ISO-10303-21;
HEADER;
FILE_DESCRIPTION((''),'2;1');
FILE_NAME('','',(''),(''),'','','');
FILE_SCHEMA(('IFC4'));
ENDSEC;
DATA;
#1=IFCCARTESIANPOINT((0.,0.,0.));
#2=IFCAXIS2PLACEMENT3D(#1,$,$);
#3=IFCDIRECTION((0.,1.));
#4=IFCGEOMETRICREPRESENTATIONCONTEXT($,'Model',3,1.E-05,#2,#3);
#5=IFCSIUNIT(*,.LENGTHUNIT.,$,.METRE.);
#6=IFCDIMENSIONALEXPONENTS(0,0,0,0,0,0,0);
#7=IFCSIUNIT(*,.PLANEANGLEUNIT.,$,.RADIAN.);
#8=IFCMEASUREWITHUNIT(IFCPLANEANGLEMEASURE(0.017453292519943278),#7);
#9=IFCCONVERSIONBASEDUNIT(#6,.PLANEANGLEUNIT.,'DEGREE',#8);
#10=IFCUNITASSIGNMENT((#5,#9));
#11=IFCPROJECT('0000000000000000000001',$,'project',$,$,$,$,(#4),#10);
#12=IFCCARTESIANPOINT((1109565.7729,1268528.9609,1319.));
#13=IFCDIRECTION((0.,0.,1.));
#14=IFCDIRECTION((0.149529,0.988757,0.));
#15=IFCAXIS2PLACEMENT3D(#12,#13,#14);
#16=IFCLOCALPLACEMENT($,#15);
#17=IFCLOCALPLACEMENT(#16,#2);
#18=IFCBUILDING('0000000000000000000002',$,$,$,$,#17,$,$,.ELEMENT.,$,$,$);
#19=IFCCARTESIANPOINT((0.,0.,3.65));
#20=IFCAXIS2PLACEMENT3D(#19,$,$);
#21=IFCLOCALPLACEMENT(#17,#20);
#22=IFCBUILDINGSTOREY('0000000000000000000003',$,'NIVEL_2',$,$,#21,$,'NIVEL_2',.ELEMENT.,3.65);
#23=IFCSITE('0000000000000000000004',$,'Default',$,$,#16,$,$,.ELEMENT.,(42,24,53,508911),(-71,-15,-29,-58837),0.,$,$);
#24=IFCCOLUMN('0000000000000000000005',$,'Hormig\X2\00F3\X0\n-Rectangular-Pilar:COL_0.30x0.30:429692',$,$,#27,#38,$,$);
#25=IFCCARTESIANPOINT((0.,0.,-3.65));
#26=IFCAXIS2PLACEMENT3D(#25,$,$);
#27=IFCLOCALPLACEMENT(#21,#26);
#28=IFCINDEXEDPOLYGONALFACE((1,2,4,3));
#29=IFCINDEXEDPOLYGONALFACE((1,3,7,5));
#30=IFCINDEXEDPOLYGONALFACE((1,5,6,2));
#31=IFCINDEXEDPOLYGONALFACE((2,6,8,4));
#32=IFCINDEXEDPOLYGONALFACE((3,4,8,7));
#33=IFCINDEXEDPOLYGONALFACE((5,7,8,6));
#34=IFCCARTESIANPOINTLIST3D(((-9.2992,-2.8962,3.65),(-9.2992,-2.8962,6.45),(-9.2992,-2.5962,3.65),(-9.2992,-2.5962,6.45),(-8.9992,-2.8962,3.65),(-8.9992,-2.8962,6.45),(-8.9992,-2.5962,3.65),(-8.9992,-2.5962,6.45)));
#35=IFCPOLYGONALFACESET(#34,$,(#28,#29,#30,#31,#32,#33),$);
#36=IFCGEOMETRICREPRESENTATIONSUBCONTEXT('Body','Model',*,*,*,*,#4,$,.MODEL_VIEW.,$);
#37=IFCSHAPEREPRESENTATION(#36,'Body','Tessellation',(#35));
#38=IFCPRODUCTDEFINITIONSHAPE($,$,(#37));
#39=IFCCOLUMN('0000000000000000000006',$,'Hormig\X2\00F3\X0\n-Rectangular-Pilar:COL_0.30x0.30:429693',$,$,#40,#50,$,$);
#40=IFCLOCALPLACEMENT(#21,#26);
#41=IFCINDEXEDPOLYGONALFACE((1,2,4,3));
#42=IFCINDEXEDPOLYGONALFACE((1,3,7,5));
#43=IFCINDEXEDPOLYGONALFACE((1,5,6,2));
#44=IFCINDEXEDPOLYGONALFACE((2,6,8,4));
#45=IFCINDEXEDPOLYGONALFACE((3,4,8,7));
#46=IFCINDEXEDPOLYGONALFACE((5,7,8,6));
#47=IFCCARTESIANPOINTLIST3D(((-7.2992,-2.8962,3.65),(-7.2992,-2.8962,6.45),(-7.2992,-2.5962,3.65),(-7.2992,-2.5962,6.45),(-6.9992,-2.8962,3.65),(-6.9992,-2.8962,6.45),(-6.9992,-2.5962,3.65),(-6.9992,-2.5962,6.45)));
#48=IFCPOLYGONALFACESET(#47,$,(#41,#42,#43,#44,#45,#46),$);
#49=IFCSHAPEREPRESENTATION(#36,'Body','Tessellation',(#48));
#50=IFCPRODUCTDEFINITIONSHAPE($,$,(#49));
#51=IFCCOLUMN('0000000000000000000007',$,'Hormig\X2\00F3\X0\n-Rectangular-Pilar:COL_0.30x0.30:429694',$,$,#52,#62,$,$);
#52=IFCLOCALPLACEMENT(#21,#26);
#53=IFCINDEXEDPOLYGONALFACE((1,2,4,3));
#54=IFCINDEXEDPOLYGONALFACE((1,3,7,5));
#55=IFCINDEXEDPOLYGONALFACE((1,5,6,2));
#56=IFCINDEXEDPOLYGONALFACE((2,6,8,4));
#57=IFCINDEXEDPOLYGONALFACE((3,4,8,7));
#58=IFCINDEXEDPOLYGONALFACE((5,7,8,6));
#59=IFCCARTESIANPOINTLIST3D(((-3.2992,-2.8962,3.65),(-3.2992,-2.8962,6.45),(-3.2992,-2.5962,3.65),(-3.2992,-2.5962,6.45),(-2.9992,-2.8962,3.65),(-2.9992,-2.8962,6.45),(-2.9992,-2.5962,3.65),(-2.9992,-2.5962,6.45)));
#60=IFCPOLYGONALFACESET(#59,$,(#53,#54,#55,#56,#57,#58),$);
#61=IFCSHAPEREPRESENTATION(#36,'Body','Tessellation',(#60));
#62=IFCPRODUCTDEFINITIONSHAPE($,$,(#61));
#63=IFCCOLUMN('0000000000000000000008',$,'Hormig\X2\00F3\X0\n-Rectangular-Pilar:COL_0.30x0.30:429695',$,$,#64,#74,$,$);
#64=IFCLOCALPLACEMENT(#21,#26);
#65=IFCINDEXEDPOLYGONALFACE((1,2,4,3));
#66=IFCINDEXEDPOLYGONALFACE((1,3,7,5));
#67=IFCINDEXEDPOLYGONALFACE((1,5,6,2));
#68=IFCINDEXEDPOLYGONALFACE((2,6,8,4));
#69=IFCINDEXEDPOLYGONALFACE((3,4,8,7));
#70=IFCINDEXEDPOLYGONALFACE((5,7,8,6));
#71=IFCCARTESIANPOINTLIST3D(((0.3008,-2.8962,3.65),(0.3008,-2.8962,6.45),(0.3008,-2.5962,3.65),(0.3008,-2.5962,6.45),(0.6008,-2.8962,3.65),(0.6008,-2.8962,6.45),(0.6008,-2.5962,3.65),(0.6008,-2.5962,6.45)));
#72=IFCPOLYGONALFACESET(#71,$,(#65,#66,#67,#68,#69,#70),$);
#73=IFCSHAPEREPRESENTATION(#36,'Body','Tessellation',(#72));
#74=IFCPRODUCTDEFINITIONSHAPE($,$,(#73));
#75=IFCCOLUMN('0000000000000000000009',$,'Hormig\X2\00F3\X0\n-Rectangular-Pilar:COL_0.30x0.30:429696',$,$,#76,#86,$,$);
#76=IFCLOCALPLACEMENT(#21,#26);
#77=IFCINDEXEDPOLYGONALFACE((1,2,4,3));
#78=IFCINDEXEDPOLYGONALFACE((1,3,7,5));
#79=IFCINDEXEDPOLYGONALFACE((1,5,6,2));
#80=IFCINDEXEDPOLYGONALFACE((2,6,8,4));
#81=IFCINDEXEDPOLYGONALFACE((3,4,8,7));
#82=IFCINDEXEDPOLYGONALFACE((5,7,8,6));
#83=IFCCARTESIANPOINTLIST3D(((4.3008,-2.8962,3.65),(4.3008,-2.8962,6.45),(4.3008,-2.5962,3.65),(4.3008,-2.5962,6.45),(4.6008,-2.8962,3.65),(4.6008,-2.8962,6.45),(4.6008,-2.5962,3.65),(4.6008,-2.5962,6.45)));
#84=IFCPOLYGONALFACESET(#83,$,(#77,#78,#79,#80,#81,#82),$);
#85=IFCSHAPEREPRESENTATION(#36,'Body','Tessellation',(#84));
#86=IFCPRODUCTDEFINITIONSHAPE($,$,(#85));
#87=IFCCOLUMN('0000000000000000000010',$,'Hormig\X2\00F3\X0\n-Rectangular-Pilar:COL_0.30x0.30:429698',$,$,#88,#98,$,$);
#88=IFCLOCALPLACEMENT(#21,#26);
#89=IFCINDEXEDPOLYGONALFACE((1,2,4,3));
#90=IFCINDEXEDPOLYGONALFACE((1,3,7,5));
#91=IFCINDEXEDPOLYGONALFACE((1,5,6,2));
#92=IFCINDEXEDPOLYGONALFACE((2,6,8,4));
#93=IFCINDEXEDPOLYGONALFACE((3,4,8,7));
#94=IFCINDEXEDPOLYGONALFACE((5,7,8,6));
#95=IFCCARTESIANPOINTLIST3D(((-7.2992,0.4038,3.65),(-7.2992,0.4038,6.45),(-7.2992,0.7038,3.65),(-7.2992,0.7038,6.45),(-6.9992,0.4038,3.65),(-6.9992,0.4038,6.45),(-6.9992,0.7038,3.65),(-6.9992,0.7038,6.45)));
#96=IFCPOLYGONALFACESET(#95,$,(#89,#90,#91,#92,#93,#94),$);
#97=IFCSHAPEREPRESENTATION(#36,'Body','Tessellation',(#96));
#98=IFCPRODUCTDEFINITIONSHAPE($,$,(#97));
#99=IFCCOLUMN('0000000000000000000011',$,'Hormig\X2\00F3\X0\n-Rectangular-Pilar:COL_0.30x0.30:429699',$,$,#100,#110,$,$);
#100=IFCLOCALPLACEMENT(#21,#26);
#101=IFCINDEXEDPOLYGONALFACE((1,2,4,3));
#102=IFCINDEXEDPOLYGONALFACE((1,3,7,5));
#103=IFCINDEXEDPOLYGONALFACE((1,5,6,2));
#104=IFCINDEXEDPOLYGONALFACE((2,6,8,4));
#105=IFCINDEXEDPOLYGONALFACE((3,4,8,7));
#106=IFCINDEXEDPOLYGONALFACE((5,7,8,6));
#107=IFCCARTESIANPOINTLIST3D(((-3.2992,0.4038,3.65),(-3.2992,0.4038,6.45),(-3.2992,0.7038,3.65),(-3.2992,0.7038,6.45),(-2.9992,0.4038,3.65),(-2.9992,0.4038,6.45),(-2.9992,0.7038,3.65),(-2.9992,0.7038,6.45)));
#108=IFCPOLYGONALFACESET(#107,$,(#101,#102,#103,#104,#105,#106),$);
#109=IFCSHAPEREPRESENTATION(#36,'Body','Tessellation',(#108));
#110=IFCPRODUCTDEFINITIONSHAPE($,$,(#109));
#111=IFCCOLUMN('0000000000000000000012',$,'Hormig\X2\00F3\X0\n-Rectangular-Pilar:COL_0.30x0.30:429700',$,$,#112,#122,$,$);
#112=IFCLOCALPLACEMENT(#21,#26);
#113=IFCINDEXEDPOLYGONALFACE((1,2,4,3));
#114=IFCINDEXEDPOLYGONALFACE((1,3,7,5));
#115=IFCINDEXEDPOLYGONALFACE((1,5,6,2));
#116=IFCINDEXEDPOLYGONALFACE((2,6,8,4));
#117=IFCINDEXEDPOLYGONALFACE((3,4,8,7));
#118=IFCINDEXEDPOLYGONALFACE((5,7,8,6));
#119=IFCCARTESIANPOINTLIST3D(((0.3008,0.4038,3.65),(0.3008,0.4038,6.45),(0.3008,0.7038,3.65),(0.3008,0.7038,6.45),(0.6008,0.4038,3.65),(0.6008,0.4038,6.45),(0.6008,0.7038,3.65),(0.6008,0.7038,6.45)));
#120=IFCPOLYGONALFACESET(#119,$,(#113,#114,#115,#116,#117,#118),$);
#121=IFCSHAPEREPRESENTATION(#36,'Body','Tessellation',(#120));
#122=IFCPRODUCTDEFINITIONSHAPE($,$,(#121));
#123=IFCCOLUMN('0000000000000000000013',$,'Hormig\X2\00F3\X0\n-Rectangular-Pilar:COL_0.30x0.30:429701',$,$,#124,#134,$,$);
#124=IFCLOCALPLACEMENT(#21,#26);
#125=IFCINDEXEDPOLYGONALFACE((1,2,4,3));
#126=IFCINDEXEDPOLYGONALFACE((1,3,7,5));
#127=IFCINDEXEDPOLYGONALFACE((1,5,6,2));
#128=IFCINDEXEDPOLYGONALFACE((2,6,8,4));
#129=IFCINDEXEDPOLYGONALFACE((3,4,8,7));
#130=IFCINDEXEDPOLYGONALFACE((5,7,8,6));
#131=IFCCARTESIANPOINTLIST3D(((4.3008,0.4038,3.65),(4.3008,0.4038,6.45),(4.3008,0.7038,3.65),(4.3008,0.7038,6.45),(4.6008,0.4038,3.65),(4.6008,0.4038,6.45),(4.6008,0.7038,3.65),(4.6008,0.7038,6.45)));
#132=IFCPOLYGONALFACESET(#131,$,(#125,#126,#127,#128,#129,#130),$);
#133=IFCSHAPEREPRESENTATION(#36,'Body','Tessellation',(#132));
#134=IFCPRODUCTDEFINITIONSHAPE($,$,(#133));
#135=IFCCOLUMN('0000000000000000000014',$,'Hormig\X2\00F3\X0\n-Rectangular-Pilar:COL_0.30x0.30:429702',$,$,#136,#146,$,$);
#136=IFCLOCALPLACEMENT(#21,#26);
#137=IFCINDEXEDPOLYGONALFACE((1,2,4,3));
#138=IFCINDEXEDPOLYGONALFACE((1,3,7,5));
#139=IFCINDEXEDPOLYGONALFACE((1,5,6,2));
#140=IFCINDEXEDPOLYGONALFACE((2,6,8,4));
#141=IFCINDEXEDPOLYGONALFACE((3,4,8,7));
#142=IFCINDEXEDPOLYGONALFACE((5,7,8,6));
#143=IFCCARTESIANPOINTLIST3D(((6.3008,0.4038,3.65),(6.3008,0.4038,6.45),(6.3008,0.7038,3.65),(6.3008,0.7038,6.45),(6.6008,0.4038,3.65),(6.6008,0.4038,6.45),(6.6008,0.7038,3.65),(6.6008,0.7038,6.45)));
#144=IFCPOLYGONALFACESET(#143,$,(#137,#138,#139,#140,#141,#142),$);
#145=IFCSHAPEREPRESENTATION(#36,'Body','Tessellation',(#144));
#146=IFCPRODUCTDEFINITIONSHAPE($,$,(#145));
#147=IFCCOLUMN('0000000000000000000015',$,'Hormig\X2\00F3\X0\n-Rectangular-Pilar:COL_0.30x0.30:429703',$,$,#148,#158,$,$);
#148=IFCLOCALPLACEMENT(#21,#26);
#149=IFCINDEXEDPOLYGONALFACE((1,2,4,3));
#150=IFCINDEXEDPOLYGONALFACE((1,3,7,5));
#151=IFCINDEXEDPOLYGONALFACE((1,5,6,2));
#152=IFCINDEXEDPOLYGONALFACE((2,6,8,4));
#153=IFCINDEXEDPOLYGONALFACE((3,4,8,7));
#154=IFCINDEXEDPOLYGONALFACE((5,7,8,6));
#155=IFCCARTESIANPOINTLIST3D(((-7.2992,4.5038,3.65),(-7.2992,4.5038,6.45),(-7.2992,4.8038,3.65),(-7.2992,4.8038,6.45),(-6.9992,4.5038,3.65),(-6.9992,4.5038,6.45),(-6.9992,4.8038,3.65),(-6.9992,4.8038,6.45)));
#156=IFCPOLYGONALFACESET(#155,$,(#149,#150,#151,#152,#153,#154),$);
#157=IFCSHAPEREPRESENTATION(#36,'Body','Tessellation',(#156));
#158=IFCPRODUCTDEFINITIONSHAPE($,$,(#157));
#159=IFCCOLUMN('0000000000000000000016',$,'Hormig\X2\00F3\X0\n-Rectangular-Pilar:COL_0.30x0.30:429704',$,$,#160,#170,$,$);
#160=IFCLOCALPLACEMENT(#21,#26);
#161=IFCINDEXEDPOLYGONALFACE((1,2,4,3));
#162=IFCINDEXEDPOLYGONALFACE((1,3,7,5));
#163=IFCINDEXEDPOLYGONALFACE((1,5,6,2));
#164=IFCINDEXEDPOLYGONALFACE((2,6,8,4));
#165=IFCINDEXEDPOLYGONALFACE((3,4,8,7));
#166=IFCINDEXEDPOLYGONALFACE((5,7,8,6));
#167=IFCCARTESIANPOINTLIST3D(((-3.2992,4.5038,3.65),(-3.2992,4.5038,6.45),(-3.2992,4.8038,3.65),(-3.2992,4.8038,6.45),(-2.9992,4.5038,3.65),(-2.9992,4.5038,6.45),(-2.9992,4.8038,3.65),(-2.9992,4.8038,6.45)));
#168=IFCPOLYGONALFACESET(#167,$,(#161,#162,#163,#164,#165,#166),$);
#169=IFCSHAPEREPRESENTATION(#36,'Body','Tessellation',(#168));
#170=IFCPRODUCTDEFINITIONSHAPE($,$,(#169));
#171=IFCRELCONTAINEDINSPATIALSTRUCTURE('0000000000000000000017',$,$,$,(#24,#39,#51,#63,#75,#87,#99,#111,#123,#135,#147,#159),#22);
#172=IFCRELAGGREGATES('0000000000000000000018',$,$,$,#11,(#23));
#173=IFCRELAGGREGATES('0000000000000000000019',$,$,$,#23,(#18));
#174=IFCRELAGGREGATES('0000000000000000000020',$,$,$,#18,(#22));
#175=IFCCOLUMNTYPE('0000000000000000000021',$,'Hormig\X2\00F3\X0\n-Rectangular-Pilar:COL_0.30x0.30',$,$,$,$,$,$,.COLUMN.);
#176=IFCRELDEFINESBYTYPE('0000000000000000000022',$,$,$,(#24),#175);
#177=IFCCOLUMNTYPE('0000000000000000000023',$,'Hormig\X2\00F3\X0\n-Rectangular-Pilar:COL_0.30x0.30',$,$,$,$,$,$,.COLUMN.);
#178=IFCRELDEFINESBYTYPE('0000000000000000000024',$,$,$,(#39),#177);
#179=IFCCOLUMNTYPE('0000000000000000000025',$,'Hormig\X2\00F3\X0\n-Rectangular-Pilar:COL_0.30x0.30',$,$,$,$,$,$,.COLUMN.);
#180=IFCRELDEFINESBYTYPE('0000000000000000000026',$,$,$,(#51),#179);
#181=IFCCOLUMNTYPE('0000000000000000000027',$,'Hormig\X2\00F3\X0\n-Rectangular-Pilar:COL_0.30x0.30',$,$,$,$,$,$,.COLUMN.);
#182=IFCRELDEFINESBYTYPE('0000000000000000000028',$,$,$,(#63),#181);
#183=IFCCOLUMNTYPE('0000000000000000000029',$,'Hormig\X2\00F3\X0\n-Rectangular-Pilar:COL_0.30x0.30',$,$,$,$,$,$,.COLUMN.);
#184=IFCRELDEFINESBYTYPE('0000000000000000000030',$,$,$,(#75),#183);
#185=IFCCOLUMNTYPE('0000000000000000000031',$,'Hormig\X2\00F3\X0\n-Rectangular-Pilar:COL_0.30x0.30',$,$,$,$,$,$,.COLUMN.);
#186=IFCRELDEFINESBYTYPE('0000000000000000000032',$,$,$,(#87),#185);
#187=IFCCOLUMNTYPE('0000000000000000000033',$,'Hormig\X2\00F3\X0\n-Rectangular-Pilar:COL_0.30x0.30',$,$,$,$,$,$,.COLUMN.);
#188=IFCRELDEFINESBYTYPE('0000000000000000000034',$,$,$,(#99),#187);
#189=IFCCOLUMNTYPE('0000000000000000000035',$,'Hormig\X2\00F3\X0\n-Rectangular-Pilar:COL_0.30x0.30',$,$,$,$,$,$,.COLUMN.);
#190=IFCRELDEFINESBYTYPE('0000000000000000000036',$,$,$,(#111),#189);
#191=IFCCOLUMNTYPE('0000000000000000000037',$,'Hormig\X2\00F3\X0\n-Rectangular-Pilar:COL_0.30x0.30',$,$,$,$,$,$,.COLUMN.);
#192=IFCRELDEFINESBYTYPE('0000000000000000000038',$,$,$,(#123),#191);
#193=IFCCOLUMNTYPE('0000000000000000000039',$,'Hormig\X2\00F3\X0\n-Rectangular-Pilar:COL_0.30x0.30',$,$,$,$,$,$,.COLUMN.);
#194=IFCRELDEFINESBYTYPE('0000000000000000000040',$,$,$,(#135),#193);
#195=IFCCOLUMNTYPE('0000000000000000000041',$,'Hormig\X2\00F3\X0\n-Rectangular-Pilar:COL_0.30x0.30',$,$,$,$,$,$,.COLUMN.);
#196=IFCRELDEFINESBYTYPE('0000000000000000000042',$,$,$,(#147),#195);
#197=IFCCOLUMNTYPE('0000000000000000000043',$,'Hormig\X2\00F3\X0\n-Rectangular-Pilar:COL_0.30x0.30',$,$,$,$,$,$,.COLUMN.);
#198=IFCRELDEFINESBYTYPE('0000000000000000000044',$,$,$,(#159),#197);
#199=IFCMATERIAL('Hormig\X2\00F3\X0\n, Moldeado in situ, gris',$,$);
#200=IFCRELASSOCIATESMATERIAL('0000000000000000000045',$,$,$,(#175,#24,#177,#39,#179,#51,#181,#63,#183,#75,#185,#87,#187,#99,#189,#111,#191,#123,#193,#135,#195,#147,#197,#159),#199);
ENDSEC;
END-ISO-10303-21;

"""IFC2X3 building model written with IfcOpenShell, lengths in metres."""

from ifc_helpers import new_model, entity, si_unit, converted_unit, direction, frame, frame_2d, origin, origin_2d_with_axis, place, context, subcontext, project, spatial, rectangle, extrude, source, transform, mapped, material, type_object, type_shapes, element, save


model = new_model("IFC2X3")

# Units and contexts
model_context = context("Model", 3, precision=1e-05, world=origin(), true_north=direction((0.0, 1.0)))
body_context = subcontext(model_context, "Body", "Model", "MODEL_VIEW")
ifc_project = project(units=[si_unit("LENGTHUNIT", "METRE"), converted_unit("PLANEANGLEUNIT", "DEGREE", entity("IfcPlaneAngleMeasure", 0.017453292519943278), si_unit("PLANEANGLEUNIT", "RADIAN"), dimensions=[0, 0, 0, 0, 0, 0, 0])], contexts=[model_context])

# Site, building, storey
site_placement = place(None, frame((1109565.7729, 1268528.9609, 1319.0), z_axis=(0.0, 0.0, 1.0), x_axis=(0.149529, 0.988757, 0.0)))
site = spatial("IfcSite", under=ifc_project, at=site_placement, Name="Default", CompositionType="ELEMENT", RefLatitude=(42, 24, 53, 508911), RefLongitude=(-71, -15, -29, -58837), RefElevation=0.0)
building_placement = place(site_placement, origin())
building = spatial("IfcBuilding", under=site, at=building_placement, CompositionType="ELEMENT")
storey_placement = place(building_placement, frame((0.0, 0.0, 3.65)))
storey = spatial("IfcBuildingStorey", under=building, at=storey_placement, Name="NIVEL_2", LongName="NIVEL_2", CompositionType="ELEMENT", Elevation=3.65)

# Columns
ifc_material_1 = material(Name="Hormigón, Moldeado in situ, gris")
column_type_1 = type_object("IfcColumnType", Name="Hormigón-Rectangular-Pilar:COL_0.30x0.30", PredefinedType="COLUMN", material=ifc_material_1)
shared_shape_1 = source(origin(), body_context, "Body", "SweptSolid", [
    extrude(rectangle(XDim=0.3, YDim=0.3, at=origin_2d_with_axis()), frame((-9.1492, -2.7462, 3.65)), (0.0, 0.0, 1.0), 2.8),
])
type_shapes(column_type_1, [shared_shape_1])
column_1_placement = place(storey_placement, frame((0.0, 0.0, -3.65)))
element("IfcColumn", 1, at=column_1_placement, inside=storey, type_object=column_type_1, material=ifc_material_1, Name="Hormigón-Rectangular-Pilar:COL_0.30x0.30:429692", context=body_context, shape_type="MappedRepresentation", body=[
    mapped(shared_shape_1, transform((0.0, 0.0, 0.0), scale=1.0)),
])
column_type_2 = type_object("IfcColumnType", Name="Hormigón-Rectangular-Pilar:COL_0.30x0.30", PredefinedType="COLUMN", material=ifc_material_1)
shared_shape_2 = source(origin(), body_context, "Body", "SweptSolid", [
    extrude(rectangle(XDim=0.3, YDim=0.3, at=origin_2d_with_axis()), frame((-7.1492, -2.7462, 3.65)), (0.0, 0.0, 1.0), 2.8),
])
type_shapes(column_type_2, [shared_shape_2])
column_2_placement = place(storey_placement, frame((0.0, 0.0, -3.65)))
element("IfcColumn", 2, at=column_2_placement, inside=storey, type_object=column_type_2, material=ifc_material_1, Name="Hormigón-Rectangular-Pilar:COL_0.30x0.30:429693", context=body_context, shape_type="MappedRepresentation", body=[
    mapped(shared_shape_2, transform((0.0, 0.0, 0.0), scale=1.0)),
])
column_type_3 = type_object("IfcColumnType", Name="Hormigón-Rectangular-Pilar:COL_0.30x0.30", PredefinedType="COLUMN", material=ifc_material_1)
shared_shape_3 = source(origin(), body_context, "Body", "SweptSolid", [
    extrude(rectangle(XDim=0.3, YDim=0.3, at=origin_2d_with_axis()), frame((-3.1492, -2.7462, 3.65)), (0.0, 0.0, 1.0), 2.8),
])
type_shapes(column_type_3, [shared_shape_3])
column_3_placement = place(storey_placement, frame((0.0, 0.0, -3.65)))
element("IfcColumn", 3, at=column_3_placement, inside=storey, type_object=column_type_3, material=ifc_material_1, Name="Hormigón-Rectangular-Pilar:COL_0.30x0.30:429694", context=body_context, shape_type="MappedRepresentation", body=[
    mapped(shared_shape_3, transform((0.0, 0.0, 0.0), scale=1.0)),
])
column_type_4 = type_object("IfcColumnType", Name="Hormigón-Rectangular-Pilar:COL_0.30x0.30", PredefinedType="COLUMN", material=ifc_material_1)
shared_shape_4 = source(origin(), body_context, "Body", "SweptSolid", [
    extrude(rectangle(XDim=0.3, YDim=0.3, at=frame_2d((0.0, 0.0), x_axis=(1.0, 0.0))), frame((0.4508, -2.7462, 3.65)), (0.0, 0.0, 1.0), 2.8),
])
type_shapes(column_type_4, [shared_shape_4])
column_4_placement = place(storey_placement, frame((0.0, 0.0, -3.65)))
element("IfcColumn", 4, at=column_4_placement, inside=storey, type_object=column_type_4, material=ifc_material_1, Name="Hormigón-Rectangular-Pilar:COL_0.30x0.30:429695", context=body_context, shape_type="MappedRepresentation", body=[
    mapped(shared_shape_4, transform((0.0, 0.0, 0.0), scale=1.0)),
])
column_type_5 = type_object("IfcColumnType", Name="Hormigón-Rectangular-Pilar:COL_0.30x0.30", PredefinedType="COLUMN", material=ifc_material_1)
shared_shape_5 = source(origin(), body_context, "Body", "SweptSolid", [
    extrude(rectangle(XDim=0.3, YDim=0.3, at=origin_2d_with_axis()), frame((4.4508, -2.7462, 3.65)), (0.0, 0.0, 1.0), 2.8),
])
type_shapes(column_type_5, [shared_shape_5])
column_5_placement = place(storey_placement, frame((0.0, 0.0, -3.65)))
element("IfcColumn", 5, at=column_5_placement, inside=storey, type_object=column_type_5, material=ifc_material_1, Name="Hormigón-Rectangular-Pilar:COL_0.30x0.30:429696", context=body_context, shape_type="MappedRepresentation", body=[
    mapped(shared_shape_5, transform((0.0, 0.0, 0.0), scale=1.0)),
])
column_type_6 = type_object("IfcColumnType", Name="Hormigón-Rectangular-Pilar:COL_0.30x0.30", PredefinedType="COLUMN", material=ifc_material_1)
shared_shape_6 = source(origin(), body_context, "Body", "SweptSolid", [
    extrude(rectangle(XDim=0.3, YDim=0.3, at=frame_2d((0.0, 0.0), x_axis=(1.0, 0.0))), frame((-7.1492, 0.5538, 3.65)), (0.0, 0.0, 1.0), 2.8),
])
type_shapes(column_type_6, [shared_shape_6])
column_6_placement = place(storey_placement, frame((0.0, 0.0, -3.65)))
element("IfcColumn", 6, at=column_6_placement, inside=storey, type_object=column_type_6, material=ifc_material_1, Name="Hormigón-Rectangular-Pilar:COL_0.30x0.30:429698", context=body_context, shape_type="MappedRepresentation", body=[
    mapped(shared_shape_6, transform((0.0, 0.0, 0.0), scale=1.0)),
])
column_type_7 = type_object("IfcColumnType", Name="Hormigón-Rectangular-Pilar:COL_0.30x0.30", PredefinedType="COLUMN", material=ifc_material_1)
shared_shape_7 = source(origin(), body_context, "Body", "SweptSolid", [
    extrude(rectangle(XDim=0.3, YDim=0.3, at=origin_2d_with_axis()), frame((-3.1492, 0.5538, 3.65)), (0.0, 0.0, 1.0), 2.8),
])
type_shapes(column_type_7, [shared_shape_7])
column_7_placement = place(storey_placement, frame((0.0, 0.0, -3.65)))
element("IfcColumn", 7, at=column_7_placement, inside=storey, type_object=column_type_7, material=ifc_material_1, Name="Hormigón-Rectangular-Pilar:COL_0.30x0.30:429699", context=body_context, shape_type="MappedRepresentation", body=[
    mapped(shared_shape_7, transform((0.0, 0.0, 0.0), scale=1.0)),
])
column_type_8 = type_object("IfcColumnType", Name="Hormigón-Rectangular-Pilar:COL_0.30x0.30", PredefinedType="COLUMN", material=ifc_material_1)
shared_shape_8 = source(origin(), body_context, "Body", "SweptSolid", [
    extrude(rectangle(XDim=0.3, YDim=0.3, at=frame_2d((0.0, 0.0), x_axis=(1.0, 0.0))), frame((0.4508, 0.5538, 3.65)), (0.0, 0.0, 1.0), 2.8),
])
type_shapes(column_type_8, [shared_shape_8])
column_8_placement = place(storey_placement, frame((0.0, 0.0, -3.65)))
element("IfcColumn", 8, at=column_8_placement, inside=storey, type_object=column_type_8, material=ifc_material_1, Name="Hormigón-Rectangular-Pilar:COL_0.30x0.30:429700", context=body_context, shape_type="MappedRepresentation", body=[
    mapped(shared_shape_8, transform((0.0, 0.0, 0.0), scale=1.0)),
])
column_type_9 = type_object("IfcColumnType", Name="Hormigón-Rectangular-Pilar:COL_0.30x0.30", PredefinedType="COLUMN", material=ifc_material_1)
shared_shape_9 = source(origin(), body_context, "Body", "SweptSolid", [
    extrude(rectangle(XDim=0.3, YDim=0.3, at=origin_2d_with_axis()), frame((4.4508, 0.5538, 3.65)), (0.0, 0.0, 1.0), 2.8),
])
type_shapes(column_type_9, [shared_shape_9])
column_9_placement = place(storey_placement, frame((0.0, 0.0, -3.65)))
element("IfcColumn", 9, at=column_9_placement, inside=storey, type_object=column_type_9, material=ifc_material_1, Name="Hormigón-Rectangular-Pilar:COL_0.30x0.30:429701", context=body_context, shape_type="MappedRepresentation", body=[
    mapped(shared_shape_9, transform((0.0, 0.0, 0.0), scale=1.0)),
])
column_type_10 = type_object("IfcColumnType", Name="Hormigón-Rectangular-Pilar:COL_0.30x0.30", PredefinedType="COLUMN", material=ifc_material_1)
shared_shape_10 = source(origin(), body_context, "Body", "SweptSolid", [
    extrude(rectangle(XDim=0.3, YDim=0.3, at=frame_2d((0.0, 0.0), x_axis=(1.0, 0.0))), frame((6.4508, 0.5538, 3.65)), (0.0, 0.0, 1.0), 2.8),
])
type_shapes(column_type_10, [shared_shape_10])
column_10_placement = place(storey_placement, frame((0.0, 0.0, -3.65)))
element("IfcColumn", 10, at=column_10_placement, inside=storey, type_object=column_type_10, material=ifc_material_1, Name="Hormigón-Rectangular-Pilar:COL_0.30x0.30:429702", context=body_context, shape_type="MappedRepresentation", body=[
    mapped(shared_shape_10, transform((0.0, 0.0, 0.0), scale=1.0)),
])
column_type_11 = type_object("IfcColumnType", Name="Hormigón-Rectangular-Pilar:COL_0.30x0.30", PredefinedType="COLUMN", material=ifc_material_1)
shared_shape_11 = source(origin(), body_context, "Body", "SweptSolid", [
    extrude(rectangle(XDim=0.3, YDim=0.3, at=frame_2d((0.0, 0.0), x_axis=(1.0, 0.0))), frame((-7.1492, 4.6538, 3.65)), (0.0, 0.0, 1.0), 2.8),
])
type_shapes(column_type_11, [shared_shape_11])
column_11_placement = place(storey_placement, frame((0.0, 0.0, -3.65)))
element("IfcColumn", 11, at=column_11_placement, inside=storey, type_object=column_type_11, material=ifc_material_1, Name="Hormigón-Rectangular-Pilar:COL_0.30x0.30:429703", context=body_context, shape_type="MappedRepresentation", body=[
    mapped(shared_shape_11, transform((0.0, 0.0, 0.0), scale=1.0)),
])
column_type_12 = type_object("IfcColumnType", Name="Hormigón-Rectangular-Pilar:COL_0.30x0.30", PredefinedType="COLUMN", material=ifc_material_1)
shared_shape_12 = source(origin(), body_context, "Body", "SweptSolid", [
    extrude(rectangle(XDim=0.3, YDim=0.3, at=origin_2d_with_axis()), frame((-3.1492, 4.6538, 3.65)), (0.0, 0.0, 1.0), 2.8),
])
type_shapes(column_type_12, [shared_shape_12])
column_12_placement = place(storey_placement, frame((0.0, 0.0, -3.65)))
element("IfcColumn", 12, at=column_12_placement, inside=storey, type_object=column_type_12, material=ifc_material_1, Name="Hormigón-Rectangular-Pilar:COL_0.30x0.30:429704", context=body_context, shape_type="MappedRepresentation", body=[
    mapped(shared_shape_12, transform((0.0, 0.0, 0.0), scale=1.0)),
])

save(model, "model.ifc")
